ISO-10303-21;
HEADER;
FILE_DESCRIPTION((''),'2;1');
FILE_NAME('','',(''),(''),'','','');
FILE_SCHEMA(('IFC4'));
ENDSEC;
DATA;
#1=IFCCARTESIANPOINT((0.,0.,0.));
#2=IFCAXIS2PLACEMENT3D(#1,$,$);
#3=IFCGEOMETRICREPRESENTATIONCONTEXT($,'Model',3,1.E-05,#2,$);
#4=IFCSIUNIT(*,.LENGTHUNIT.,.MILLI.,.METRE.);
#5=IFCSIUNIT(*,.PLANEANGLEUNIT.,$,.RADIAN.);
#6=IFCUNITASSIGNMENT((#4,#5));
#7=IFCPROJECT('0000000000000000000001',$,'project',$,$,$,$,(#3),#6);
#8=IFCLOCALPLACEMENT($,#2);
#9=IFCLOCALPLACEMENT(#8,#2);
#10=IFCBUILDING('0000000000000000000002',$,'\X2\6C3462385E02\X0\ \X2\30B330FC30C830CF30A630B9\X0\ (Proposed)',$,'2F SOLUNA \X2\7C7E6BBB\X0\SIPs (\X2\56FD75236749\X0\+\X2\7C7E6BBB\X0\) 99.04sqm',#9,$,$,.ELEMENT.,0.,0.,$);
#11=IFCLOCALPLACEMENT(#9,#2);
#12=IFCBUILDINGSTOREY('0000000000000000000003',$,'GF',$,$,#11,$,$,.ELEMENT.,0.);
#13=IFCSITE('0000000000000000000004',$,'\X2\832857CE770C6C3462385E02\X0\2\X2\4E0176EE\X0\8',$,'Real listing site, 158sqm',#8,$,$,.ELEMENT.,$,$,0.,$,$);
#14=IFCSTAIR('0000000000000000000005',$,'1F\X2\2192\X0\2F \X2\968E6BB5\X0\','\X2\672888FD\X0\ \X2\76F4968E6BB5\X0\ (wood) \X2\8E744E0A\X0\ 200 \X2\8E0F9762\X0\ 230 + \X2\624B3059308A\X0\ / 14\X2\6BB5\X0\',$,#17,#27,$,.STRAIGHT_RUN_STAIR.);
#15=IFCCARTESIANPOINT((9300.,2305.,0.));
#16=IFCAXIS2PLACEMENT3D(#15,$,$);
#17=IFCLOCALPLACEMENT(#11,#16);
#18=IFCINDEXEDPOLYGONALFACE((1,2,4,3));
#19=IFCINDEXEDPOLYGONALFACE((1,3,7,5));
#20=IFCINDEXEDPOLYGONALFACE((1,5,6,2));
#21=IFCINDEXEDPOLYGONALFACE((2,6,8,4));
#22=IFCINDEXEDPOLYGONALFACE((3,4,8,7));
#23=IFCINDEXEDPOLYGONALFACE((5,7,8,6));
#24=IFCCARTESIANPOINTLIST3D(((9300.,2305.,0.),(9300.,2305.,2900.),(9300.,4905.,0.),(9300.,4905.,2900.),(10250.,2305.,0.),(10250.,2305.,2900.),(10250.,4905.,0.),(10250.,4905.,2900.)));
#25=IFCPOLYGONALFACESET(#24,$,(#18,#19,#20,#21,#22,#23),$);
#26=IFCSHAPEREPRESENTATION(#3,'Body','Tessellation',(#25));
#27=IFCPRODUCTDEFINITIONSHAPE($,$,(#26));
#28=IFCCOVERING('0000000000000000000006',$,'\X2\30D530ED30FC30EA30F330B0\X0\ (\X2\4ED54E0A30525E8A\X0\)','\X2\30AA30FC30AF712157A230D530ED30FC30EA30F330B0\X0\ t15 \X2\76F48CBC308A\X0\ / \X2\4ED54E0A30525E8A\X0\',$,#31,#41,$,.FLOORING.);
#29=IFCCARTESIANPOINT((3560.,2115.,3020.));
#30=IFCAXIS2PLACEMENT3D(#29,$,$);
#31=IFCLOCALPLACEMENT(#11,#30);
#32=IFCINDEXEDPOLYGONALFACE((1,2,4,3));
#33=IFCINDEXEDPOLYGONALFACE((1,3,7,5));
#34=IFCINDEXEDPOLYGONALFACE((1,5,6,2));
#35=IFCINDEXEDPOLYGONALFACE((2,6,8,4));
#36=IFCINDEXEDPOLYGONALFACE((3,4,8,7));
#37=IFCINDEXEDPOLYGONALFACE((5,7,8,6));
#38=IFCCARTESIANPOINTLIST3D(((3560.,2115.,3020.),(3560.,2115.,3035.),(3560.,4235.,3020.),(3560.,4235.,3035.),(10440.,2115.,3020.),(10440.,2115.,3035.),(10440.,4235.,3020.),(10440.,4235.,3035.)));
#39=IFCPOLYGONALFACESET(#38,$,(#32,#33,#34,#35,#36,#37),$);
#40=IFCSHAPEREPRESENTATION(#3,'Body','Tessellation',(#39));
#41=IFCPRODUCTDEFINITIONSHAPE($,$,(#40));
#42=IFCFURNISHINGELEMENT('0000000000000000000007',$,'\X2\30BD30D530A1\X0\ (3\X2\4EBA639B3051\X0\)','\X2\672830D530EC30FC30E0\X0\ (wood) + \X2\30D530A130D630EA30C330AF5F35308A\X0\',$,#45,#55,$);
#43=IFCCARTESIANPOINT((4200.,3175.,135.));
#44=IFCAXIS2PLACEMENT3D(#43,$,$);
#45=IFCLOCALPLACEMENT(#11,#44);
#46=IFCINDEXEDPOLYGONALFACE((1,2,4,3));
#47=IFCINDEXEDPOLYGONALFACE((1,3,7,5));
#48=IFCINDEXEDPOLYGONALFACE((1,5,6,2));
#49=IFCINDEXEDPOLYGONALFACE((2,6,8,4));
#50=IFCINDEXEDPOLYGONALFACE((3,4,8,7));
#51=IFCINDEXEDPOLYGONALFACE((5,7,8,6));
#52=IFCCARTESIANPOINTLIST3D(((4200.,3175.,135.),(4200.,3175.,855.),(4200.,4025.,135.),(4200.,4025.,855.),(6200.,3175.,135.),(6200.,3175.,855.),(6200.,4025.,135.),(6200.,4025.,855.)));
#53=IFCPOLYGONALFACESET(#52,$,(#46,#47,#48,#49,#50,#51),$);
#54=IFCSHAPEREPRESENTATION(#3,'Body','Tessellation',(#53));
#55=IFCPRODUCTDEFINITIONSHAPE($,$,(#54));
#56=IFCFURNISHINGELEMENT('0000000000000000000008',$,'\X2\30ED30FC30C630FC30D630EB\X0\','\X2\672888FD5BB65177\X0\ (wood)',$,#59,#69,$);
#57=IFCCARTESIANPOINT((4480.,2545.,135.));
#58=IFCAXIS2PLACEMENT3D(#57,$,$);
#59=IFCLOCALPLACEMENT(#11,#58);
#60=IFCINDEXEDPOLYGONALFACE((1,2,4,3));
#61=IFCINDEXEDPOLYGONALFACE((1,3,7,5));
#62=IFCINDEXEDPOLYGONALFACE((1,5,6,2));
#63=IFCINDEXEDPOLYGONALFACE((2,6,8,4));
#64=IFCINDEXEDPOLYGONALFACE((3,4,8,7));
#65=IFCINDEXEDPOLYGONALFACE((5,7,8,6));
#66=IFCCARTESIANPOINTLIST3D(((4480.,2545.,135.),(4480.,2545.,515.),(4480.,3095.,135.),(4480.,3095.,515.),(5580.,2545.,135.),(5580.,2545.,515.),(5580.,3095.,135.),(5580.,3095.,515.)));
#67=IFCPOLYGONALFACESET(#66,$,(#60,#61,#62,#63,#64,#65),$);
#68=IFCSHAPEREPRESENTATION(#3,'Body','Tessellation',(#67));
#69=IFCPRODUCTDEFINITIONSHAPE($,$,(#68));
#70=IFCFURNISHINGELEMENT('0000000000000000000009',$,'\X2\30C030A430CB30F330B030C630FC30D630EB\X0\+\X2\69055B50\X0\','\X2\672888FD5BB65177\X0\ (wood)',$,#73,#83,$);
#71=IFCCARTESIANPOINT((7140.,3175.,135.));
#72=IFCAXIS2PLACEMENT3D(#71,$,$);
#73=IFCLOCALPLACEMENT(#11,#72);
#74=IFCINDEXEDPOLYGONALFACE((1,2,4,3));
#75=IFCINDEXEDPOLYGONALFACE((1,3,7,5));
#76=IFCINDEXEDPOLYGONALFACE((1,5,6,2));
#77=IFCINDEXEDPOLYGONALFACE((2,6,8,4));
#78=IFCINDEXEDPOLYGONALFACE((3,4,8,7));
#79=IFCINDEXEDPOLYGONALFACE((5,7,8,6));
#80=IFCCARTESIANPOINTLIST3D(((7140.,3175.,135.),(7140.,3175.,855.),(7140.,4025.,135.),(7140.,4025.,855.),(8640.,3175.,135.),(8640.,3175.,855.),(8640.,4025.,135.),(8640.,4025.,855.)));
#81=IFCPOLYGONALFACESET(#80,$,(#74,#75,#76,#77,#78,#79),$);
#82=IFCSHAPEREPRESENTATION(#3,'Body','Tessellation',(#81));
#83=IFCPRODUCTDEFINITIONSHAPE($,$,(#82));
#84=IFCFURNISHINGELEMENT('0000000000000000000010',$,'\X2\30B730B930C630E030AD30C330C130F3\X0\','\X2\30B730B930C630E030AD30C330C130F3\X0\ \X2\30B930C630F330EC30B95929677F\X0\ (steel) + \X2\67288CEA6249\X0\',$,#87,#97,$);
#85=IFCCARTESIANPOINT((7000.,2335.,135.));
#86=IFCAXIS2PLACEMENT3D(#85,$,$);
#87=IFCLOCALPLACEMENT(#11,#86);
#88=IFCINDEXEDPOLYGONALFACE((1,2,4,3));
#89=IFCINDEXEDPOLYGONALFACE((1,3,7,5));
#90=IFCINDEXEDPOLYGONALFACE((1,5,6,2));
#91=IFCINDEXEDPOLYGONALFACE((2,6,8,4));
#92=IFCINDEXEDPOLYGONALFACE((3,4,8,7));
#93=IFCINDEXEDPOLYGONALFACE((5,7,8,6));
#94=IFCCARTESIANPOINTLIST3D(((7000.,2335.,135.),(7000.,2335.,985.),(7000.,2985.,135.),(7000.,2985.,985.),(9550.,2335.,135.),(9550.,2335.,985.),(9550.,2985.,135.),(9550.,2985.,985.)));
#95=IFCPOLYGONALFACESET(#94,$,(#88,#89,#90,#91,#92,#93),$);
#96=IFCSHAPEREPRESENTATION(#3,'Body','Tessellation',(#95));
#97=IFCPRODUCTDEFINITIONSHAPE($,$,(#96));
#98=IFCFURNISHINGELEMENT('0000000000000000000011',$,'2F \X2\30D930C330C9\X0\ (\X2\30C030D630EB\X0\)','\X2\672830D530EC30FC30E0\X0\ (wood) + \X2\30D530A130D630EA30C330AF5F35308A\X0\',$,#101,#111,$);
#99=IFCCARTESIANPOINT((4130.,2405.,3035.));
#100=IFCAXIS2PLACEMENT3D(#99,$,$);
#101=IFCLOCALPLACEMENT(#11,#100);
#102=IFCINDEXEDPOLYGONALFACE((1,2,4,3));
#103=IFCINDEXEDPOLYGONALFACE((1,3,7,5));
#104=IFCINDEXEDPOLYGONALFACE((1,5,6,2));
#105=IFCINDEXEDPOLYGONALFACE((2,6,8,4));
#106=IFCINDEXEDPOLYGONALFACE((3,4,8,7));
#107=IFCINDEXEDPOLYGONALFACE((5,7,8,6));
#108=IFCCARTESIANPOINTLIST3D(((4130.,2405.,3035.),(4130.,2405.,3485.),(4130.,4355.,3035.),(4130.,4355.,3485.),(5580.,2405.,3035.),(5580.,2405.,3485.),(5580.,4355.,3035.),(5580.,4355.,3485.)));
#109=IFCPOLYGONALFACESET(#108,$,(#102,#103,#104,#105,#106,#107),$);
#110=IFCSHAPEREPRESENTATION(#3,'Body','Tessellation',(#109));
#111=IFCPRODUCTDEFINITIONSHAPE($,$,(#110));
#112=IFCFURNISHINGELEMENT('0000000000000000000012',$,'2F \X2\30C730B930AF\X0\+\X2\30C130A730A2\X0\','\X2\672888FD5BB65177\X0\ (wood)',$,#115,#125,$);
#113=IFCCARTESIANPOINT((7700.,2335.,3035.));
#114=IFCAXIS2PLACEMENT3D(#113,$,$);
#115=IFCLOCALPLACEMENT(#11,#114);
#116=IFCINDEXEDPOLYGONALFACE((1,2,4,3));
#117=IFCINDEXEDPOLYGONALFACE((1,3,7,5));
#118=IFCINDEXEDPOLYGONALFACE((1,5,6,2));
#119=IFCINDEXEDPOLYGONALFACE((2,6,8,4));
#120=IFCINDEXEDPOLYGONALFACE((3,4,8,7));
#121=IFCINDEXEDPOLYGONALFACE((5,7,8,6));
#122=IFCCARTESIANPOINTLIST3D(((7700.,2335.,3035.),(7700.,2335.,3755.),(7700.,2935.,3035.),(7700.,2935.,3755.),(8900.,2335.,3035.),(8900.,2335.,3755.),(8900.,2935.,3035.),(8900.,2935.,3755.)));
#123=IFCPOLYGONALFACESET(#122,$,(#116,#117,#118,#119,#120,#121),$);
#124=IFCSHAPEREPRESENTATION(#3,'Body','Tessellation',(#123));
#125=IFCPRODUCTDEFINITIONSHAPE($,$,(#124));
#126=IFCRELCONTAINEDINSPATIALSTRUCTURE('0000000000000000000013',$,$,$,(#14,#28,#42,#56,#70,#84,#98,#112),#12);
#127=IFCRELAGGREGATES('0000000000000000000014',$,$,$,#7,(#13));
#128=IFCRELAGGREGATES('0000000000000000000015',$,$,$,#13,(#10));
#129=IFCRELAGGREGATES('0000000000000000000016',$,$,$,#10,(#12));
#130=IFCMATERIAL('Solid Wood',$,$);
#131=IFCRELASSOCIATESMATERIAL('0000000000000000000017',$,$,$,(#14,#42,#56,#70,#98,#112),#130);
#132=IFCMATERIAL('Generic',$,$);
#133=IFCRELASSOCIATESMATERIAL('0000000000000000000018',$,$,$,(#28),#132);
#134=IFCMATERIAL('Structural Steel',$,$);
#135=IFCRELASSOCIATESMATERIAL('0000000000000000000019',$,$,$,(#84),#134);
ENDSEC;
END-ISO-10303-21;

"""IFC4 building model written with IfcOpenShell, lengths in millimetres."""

from ifc_helpers import new_model, si_unit, frame, frame_2d, origin, place, context, project, spatial, rectangle, extrude, material, element, save


model = new_model("IFC4")

# Units and contexts
model_context = context("Model", 3, precision=1e-05, world=origin())
ifc_project = project(units=[si_unit("LENGTHUNIT", "METRE", prefix="MILLI"), si_unit("PLANEANGLEUNIT", "RADIAN")], contexts=[model_context])

# Site, building, storey
site_placement = place(None, origin())
site = spatial("IfcSite", under=ifc_project, at=site_placement, Name="茨城県水戸市2丁目8", ObjectType="Real listing site, 158sqm", CompositionType="ELEMENT", RefElevation=0.0)
building_placement = place(site_placement, origin())
building = spatial("IfcBuilding", under=site, at=building_placement, Name="水戸市 コートハウス (Proposed)", ObjectType="2F SOLUNA 籾殻SIPs (国産杉+籾殻) 99.04sqm", CompositionType="ELEMENT", ElevationOfRefHeight=0.0, ElevationOfTerrain=0.0)
storey_placement = place(building_placement, origin())
storey = spatial("IfcBuildingStorey", under=building, at=storey_placement, Name="GF", CompositionType="ELEMENT", Elevation=0.0)

# Shared definitions
ifc_material_1 = material(Name="Solid Wood")

# Shared definitions
ifc_material_2 = material(Name="Generic")

# Stair
stair_placement = place(storey_placement, frame((9300.0, 2305.0, 0.0)))
element("IfcStair", 1, at=stair_placement, inside=storey, material=ifc_material_1, Name="1F→2F 階段", Description="木製 直階段 (wood) 蹴上 200 踏面 230 + 手すり / 14段", PredefinedType="STRAIGHT_RUN_STAIR", context=model_context, shape_type="SweptSolid", body=[
    extrude(rectangle(XDim=950.0, YDim=2600.0, at=frame_2d((475.0, 1300.0))), frame((9300.0, 2305.0, 0.0)), (0.0, 0.0, 1.0), 2900.0),
])

# Covering
covering_placement = place(storey_placement, frame((3560.0, 2115.0, 3020.0)))
element("IfcCovering", 2, at=covering_placement, inside=storey, material=ifc_material_2, Name="フローリング (仕上げ床)", Description="オーク無垢フローリング t15 直貼り / 仕上げ床", PredefinedType="FLOORING", context=model_context, shape_type="SweptSolid", body=[
    extrude(rectangle(XDim=6880.0, YDim=2120.0, at=frame_2d((3440.0, 1060.0))), frame((3560.0, 2115.0, 3020.0)), (0.0, 0.0, 1.0), 15.0),
])

# Furnishing elements
furnishing_1_placement = place(storey_placement, frame((4200.0, 3175.0, 135.0)))
element("IfcFurnishingElement", 3, at=furnishing_1_placement, inside=storey, material=ifc_material_1, Name="ソファ (3人掛け)", Description="木フレーム (wood) + ファブリック張り", context=model_context, shape_type="SweptSolid", body=[
    extrude(rectangle(XDim=2000.0, YDim=850.0, at=frame_2d((1000.0, 425.0))), frame((4200.0, 3175.0, 135.0)), (0.0, 0.0, 1.0), 720.0),
])
furnishing_2_placement = place(storey_placement, frame((4480.0, 2545.0, 135.0)))
element("IfcFurnishingElement", 4, at=furnishing_2_placement, inside=storey, material=ifc_material_1, Name="ローテーブル", Description="木製家具 (wood)", context=model_context, shape_type="SweptSolid", body=[
    extrude(rectangle(XDim=1100.0, YDim=550.0, at=frame_2d((550.0, 275.0))), frame((4480.0, 2545.0, 135.0)), (0.0, 0.0, 1.0), 380.0),
])
furnishing_3_placement = place(storey_placement, frame((7140.0, 3175.0, 135.0)))
element("IfcFurnishingElement", 5, at=furnishing_3_placement, inside=storey, material=ifc_material_1, Name="ダイニングテーブル+椅子", Description="木製家具 (wood)", context=model_context, shape_type="SweptSolid", body=[
    extrude(rectangle(XDim=1500.0, YDim=850.0, at=frame_2d((750.0, 425.0))), frame((7140.0, 3175.0, 135.0)), (0.0, 0.0, 1.0), 720.0),
])
ifc_material_3 = material(Name="Structural Steel")
furnishing_4_placement = place(storey_placement, frame((7000.0, 2335.0, 135.0)))
element("IfcFurnishingElement", 6, at=furnishing_4_placement, inside=storey, material=ifc_material_3, Name="システムキッチン", Description="システムキッチン ステンレス天板 (steel) + 木質扉", context=model_context, shape_type="SweptSolid", body=[
    extrude(rectangle(XDim=2550.0, YDim=650.0, at=frame_2d((1275.0, 325.0))), frame((7000.0, 2335.0, 135.0)), (0.0, 0.0, 1.0), 850.0),
])
furnishing_5_placement = place(storey_placement, frame((4130.0, 2405.0, 3035.0)))
element("IfcFurnishingElement", 7, at=furnishing_5_placement, inside=storey, material=ifc_material_1, Name="2F ベッド (ダブル)", Description="木フレーム (wood) + ファブリック張り", context=model_context, shape_type="SweptSolid", body=[
    extrude(rectangle(XDim=1450.0, YDim=1950.0, at=frame_2d((725.0, 975.0))), frame((4130.0, 2405.0, 3035.0)), (0.0, 0.0, 1.0), 450.0),
])
furnishing_6_placement = place(storey_placement, frame((7700.0, 2335.0, 3035.0)))
element("IfcFurnishingElement", 8, at=furnishing_6_placement, inside=storey, material=ifc_material_1, Name="2F デスク+チェア", Description="木製家具 (wood)", context=model_context, shape_type="SweptSolid", body=[
    extrude(rectangle(XDim=1200.0, YDim=600.0, at=frame_2d((600.0, 300.0))), frame((7700.0, 2335.0, 3035.0)), (0.0, 0.0, 1.0), 720.0),
])

save(model, "model.ifc")
